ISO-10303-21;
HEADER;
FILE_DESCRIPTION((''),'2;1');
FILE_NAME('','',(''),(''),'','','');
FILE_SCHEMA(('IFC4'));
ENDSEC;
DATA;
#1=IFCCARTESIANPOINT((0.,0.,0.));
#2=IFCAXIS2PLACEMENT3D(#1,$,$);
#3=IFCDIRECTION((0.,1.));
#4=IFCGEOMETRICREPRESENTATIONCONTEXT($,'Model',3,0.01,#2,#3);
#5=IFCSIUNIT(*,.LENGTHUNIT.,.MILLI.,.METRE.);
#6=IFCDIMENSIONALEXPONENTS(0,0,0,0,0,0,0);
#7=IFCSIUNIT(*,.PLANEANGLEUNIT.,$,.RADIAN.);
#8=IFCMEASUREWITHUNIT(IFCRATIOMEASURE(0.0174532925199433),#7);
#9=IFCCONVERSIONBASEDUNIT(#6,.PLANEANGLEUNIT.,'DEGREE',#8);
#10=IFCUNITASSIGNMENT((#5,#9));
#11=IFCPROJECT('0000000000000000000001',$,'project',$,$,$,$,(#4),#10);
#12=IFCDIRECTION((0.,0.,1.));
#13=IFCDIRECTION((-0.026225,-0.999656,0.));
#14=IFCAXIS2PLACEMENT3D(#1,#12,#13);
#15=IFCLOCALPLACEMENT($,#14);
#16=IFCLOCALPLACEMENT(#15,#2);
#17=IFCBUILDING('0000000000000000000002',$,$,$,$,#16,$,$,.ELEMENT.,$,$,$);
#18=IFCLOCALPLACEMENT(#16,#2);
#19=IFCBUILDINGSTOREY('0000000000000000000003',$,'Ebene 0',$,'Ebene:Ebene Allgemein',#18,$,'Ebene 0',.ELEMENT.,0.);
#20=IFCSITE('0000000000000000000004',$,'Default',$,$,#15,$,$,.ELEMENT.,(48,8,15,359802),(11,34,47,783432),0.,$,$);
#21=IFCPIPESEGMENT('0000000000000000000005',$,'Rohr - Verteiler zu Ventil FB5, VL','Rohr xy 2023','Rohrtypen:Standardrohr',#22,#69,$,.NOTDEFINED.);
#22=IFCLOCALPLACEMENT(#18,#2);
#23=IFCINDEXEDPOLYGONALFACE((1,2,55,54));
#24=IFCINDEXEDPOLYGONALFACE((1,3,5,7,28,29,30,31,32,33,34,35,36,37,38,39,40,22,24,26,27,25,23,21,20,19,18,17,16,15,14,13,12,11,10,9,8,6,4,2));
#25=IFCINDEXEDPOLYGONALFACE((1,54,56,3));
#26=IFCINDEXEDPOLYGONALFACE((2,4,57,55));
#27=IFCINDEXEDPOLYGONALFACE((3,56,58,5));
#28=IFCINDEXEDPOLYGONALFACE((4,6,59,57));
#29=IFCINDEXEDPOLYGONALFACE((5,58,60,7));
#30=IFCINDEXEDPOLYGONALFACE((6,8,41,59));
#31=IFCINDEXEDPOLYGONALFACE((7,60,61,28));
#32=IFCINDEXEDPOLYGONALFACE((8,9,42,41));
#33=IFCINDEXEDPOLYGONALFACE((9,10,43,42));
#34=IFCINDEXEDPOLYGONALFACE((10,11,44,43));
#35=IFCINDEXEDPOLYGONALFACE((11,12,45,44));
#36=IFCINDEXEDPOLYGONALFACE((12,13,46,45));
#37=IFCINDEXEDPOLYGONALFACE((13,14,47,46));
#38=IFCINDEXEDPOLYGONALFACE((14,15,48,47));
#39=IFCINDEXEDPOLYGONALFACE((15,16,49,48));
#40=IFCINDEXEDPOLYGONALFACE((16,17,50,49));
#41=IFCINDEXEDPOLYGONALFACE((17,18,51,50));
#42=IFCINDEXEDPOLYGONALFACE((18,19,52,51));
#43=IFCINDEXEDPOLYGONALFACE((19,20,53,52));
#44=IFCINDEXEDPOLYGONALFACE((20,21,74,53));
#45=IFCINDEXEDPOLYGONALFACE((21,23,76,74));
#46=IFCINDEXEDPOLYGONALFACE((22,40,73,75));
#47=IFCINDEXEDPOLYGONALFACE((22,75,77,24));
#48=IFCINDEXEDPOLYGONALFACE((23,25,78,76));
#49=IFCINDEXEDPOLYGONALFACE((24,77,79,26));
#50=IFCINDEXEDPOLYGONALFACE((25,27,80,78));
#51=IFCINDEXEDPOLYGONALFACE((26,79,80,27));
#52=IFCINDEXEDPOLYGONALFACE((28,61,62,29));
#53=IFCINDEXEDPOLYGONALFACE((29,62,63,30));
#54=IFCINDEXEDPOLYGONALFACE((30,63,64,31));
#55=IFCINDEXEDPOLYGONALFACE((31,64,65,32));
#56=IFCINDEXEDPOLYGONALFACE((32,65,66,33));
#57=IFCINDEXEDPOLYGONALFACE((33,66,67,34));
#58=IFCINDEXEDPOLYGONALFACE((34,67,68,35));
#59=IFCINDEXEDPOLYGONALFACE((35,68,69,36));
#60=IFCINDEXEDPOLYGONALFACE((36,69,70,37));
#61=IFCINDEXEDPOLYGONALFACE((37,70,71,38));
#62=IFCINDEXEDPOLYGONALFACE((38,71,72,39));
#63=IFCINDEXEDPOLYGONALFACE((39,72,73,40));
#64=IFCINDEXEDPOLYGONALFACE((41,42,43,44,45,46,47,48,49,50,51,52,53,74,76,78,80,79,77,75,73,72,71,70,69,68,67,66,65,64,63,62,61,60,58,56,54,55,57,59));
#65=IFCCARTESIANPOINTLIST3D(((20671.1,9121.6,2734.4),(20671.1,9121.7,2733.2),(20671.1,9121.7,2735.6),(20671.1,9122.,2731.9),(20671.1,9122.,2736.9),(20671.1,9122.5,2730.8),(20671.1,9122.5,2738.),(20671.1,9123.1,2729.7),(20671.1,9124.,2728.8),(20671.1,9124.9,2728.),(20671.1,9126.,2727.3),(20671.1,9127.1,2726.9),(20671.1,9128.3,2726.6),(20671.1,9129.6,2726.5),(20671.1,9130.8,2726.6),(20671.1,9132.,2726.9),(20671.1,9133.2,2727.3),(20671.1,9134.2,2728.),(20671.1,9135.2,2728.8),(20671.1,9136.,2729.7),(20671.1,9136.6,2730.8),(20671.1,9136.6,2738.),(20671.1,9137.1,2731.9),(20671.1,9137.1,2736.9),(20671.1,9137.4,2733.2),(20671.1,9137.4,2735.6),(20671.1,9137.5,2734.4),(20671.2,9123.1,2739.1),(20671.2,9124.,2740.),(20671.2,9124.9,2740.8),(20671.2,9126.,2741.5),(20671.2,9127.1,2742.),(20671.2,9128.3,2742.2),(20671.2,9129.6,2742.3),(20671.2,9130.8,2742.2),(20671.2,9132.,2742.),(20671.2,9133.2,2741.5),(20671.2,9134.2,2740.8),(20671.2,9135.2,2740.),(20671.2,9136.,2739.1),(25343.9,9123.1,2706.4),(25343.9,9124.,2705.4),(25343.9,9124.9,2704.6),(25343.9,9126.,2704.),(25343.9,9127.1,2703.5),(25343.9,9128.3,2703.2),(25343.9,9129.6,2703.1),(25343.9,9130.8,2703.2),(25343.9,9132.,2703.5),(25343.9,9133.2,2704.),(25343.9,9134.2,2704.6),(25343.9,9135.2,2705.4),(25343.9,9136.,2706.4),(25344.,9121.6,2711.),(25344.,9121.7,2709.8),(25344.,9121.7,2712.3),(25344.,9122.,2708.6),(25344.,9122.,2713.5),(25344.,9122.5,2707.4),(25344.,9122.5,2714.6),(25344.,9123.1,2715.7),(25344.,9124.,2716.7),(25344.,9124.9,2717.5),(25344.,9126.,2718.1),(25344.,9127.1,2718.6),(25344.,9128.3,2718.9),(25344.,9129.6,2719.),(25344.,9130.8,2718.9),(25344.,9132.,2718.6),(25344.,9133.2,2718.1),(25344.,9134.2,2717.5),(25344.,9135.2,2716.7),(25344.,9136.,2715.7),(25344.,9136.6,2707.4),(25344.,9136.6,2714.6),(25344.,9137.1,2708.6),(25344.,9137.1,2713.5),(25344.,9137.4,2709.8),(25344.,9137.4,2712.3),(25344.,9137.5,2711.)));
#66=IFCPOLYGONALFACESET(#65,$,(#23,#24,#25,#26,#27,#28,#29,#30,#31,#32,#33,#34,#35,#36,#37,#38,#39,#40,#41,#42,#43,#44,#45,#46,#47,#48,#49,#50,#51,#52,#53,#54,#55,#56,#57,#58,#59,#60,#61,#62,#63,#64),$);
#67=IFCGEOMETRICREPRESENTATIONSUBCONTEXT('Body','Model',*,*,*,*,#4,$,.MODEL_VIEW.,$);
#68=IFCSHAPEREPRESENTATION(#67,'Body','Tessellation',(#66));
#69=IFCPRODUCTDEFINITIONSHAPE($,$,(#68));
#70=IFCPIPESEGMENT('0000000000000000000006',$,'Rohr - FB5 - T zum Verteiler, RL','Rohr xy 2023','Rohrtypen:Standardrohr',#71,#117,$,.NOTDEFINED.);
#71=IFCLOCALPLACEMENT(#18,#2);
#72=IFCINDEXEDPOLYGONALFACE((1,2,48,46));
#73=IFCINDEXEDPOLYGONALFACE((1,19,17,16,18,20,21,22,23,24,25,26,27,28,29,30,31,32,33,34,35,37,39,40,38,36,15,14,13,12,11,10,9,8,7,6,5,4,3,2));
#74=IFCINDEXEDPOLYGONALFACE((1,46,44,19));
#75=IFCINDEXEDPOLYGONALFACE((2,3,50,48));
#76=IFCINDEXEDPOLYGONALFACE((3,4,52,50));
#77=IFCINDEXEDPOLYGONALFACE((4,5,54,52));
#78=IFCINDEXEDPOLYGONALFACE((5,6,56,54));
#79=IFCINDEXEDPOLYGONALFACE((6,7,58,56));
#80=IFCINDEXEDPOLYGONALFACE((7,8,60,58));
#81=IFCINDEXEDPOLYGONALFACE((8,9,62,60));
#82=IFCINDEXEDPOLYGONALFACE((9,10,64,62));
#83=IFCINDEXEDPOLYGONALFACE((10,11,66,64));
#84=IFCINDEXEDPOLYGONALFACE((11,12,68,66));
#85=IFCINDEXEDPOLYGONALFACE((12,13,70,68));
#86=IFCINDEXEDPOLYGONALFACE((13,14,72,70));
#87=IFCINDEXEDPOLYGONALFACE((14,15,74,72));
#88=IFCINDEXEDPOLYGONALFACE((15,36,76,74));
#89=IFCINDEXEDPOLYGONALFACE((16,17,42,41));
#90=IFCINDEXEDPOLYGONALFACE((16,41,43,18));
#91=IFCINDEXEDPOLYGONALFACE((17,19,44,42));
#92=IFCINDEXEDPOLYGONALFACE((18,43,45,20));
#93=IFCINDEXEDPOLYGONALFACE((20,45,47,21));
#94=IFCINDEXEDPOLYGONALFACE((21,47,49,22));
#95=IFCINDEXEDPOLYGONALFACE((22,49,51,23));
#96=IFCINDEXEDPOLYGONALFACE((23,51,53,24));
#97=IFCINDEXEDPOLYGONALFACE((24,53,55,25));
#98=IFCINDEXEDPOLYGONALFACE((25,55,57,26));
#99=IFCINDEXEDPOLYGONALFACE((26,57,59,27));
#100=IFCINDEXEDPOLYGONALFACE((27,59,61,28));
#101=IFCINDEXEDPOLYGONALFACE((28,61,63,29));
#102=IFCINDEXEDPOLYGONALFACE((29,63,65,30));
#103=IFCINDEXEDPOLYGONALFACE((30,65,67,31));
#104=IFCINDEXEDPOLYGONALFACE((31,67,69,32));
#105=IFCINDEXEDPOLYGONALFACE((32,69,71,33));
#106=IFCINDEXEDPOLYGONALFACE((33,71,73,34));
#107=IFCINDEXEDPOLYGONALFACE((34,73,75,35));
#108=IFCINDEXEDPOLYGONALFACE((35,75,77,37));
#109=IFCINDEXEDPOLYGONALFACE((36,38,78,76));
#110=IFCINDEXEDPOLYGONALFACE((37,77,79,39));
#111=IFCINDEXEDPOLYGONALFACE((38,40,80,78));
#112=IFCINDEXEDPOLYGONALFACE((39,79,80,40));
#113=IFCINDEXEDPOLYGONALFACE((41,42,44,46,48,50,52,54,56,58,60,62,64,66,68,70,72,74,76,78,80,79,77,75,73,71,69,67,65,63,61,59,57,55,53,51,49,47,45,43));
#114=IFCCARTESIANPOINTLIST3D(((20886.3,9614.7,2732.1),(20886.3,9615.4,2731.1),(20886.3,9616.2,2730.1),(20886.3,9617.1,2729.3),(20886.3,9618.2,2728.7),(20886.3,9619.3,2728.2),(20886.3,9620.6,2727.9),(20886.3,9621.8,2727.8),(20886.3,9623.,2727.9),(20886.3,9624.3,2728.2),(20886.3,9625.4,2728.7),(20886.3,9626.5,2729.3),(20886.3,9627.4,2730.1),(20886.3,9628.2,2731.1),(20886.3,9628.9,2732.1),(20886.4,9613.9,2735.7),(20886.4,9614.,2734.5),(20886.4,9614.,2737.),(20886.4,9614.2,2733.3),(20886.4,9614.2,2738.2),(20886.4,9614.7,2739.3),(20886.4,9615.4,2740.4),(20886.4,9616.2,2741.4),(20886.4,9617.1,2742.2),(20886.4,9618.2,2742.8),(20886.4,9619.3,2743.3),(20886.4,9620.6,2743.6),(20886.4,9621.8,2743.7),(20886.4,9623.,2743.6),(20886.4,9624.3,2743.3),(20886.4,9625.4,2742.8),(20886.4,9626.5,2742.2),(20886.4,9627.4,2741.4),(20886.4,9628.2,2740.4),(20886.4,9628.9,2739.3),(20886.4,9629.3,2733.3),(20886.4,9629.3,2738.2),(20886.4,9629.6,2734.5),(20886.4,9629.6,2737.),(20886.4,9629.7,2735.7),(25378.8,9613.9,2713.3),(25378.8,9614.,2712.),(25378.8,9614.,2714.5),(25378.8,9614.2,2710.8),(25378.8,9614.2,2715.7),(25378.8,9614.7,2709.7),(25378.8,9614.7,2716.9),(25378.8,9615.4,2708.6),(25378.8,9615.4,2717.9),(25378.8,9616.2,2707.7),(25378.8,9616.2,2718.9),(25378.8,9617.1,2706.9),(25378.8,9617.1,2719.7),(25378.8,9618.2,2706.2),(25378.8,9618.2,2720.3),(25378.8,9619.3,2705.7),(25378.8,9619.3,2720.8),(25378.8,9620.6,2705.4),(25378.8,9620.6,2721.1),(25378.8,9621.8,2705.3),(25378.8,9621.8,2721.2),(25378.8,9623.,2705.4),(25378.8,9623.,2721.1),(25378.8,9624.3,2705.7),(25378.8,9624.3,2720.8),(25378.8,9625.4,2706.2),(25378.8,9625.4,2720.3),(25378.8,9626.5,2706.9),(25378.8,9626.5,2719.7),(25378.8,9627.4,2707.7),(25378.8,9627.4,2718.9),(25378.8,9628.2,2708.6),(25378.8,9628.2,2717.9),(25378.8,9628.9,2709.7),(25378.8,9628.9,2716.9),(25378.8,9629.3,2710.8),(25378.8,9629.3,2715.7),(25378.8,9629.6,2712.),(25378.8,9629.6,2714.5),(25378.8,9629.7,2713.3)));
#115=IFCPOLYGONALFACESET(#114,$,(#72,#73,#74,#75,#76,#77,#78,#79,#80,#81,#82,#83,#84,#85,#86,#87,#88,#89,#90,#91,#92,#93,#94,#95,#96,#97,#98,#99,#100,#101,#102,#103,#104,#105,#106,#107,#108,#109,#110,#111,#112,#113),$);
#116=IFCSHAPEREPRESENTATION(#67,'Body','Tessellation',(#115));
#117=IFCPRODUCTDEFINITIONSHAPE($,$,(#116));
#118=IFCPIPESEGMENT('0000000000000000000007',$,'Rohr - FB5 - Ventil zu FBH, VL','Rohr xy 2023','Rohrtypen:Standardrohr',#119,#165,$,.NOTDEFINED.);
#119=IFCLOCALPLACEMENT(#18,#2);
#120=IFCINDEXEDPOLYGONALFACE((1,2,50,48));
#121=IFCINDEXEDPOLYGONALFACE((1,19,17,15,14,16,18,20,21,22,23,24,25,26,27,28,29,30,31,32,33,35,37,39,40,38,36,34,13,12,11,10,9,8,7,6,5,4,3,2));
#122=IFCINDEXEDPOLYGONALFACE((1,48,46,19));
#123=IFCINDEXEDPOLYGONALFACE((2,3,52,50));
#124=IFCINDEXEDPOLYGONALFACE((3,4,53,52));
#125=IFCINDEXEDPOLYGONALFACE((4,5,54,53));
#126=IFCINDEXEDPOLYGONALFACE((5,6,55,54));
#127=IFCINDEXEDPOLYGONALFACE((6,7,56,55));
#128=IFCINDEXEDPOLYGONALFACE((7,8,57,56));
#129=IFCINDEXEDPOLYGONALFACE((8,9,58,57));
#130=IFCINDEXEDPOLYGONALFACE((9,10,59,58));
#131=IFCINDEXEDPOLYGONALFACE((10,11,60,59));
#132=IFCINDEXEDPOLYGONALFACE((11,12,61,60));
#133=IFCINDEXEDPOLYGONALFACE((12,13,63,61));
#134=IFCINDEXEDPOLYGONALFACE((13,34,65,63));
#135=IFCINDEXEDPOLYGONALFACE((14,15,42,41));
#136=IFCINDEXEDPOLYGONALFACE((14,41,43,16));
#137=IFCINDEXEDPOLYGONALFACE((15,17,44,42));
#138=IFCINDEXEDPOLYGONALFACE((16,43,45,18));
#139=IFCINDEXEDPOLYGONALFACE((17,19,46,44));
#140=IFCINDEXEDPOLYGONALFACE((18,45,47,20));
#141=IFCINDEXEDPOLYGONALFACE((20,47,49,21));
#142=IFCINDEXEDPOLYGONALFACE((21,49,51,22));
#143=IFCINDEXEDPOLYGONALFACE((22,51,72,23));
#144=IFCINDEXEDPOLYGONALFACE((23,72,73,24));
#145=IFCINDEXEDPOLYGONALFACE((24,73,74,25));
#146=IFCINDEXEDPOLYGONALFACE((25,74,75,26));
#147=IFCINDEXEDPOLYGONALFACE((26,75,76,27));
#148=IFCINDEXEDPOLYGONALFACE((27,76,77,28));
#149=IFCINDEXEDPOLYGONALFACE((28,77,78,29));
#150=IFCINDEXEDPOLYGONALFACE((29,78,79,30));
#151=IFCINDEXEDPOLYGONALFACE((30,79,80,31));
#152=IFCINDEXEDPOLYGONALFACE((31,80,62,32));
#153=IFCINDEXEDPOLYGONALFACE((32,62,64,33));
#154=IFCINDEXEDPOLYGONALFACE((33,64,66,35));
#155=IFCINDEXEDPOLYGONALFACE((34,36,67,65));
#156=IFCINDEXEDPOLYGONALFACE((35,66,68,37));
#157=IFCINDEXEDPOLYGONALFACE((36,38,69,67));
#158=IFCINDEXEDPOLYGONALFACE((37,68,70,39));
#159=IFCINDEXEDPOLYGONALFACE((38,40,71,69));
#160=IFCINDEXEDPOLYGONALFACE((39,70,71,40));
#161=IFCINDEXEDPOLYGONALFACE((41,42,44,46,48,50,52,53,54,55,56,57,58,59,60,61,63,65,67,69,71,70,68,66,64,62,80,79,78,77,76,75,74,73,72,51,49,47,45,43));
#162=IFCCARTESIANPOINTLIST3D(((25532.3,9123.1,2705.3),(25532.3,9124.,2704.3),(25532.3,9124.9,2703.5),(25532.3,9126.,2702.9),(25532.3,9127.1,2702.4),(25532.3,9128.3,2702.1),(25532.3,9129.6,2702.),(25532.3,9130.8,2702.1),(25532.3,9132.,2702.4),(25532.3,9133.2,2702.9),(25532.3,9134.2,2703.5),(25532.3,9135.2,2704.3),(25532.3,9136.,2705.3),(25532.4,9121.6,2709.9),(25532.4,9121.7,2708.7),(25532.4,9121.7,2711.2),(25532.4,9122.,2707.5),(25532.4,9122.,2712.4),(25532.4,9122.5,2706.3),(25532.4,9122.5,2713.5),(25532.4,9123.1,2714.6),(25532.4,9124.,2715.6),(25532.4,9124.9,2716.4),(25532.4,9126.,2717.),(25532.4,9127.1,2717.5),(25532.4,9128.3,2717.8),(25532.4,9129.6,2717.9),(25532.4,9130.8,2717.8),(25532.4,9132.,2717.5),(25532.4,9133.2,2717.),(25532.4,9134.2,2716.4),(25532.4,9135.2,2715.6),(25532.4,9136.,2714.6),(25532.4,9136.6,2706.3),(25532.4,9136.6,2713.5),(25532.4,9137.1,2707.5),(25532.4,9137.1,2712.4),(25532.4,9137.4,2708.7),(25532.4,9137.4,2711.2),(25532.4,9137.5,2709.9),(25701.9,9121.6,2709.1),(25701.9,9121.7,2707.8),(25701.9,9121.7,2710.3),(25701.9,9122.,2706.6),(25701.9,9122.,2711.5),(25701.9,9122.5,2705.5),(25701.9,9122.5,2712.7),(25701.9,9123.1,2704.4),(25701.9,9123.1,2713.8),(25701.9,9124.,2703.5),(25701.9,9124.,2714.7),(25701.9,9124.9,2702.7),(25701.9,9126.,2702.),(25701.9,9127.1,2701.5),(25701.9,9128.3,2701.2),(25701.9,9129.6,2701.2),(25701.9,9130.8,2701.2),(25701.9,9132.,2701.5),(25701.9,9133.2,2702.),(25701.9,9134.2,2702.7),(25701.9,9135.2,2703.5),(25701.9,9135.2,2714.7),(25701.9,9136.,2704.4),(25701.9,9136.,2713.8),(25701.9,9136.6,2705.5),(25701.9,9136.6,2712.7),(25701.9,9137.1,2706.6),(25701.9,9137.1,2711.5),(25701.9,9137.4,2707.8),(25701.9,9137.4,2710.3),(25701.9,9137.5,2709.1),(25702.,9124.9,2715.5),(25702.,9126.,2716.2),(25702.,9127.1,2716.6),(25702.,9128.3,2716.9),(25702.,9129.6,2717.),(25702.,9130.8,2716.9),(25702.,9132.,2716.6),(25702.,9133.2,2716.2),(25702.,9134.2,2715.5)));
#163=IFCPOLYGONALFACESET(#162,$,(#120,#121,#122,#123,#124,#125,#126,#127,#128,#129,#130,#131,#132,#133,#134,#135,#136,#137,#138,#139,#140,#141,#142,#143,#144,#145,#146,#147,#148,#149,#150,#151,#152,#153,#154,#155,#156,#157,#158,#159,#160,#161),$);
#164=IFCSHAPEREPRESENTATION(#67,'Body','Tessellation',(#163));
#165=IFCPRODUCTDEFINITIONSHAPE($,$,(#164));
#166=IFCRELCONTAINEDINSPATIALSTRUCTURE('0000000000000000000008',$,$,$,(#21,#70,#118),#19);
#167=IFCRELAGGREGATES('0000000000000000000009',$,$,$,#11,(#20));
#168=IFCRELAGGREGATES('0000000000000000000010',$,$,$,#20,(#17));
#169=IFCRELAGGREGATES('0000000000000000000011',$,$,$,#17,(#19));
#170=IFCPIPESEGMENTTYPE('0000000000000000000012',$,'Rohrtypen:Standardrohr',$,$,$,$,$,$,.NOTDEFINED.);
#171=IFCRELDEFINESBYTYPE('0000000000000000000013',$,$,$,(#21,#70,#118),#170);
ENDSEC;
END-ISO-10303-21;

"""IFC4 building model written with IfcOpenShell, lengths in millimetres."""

from ifc_helpers import new_model, entity, si_unit, converted_unit, direction, frame, origin, place, context, subcontext, project, spatial, indexed_curve, outline, extrude, type_object, element, save


model = new_model("IFC4")

# Units and contexts
model_context = context("Model", 3, precision=0.01, world=origin(), true_north=direction((0.0, 1.0)))
body_context = subcontext(model_context, "Body", "Model", "MODEL_VIEW")
ifc_project = project(units=[si_unit("LENGTHUNIT", "METRE", prefix="MILLI"), converted_unit("PLANEANGLEUNIT", "DEGREE", entity("IfcRatioMeasure", 0.0174532925199433), si_unit("PLANEANGLEUNIT", "RADIAN"), dimensions=[0, 0, 0, 0, 0, 0, 0])], contexts=[model_context])

# Site, building, storey
site_placement = place(None, frame((0.0, 0.0, 0.0), z_axis=(0.0, 0.0, 1.0), x_axis=(-0.026225, -0.999656, 0.0)))
site = spatial("IfcSite", under=ifc_project, at=site_placement, Name="Default", CompositionType="ELEMENT", RefLatitude=(48, 8, 15, 359802), RefLongitude=(11, 34, 47, 783432), RefElevation=0.0)
building_placement = place(site_placement, origin())
building = spatial("IfcBuilding", under=site, at=building_placement, CompositionType="ELEMENT")
storey_placement = place(building_placement, origin())
storey = spatial("IfcBuildingStorey", under=building, at=storey_placement, Name="Ebene 0", ObjectType="Ebene:Ebene Allgemein", LongName="Ebene 0", CompositionType="ELEMENT", Elevation=0.0)

# Pipe segments
pipe_segment_type = type_object("IfcPipeSegmentType", Name="Rohrtypen:Standardrohr", PredefinedType="NOTDEFINED")
pipe_segment_1_placement = place(storey_placement, origin())
element("IfcPipeSegment", 1, at=pipe_segment_1_placement, inside=storey, type_object=pipe_segment_type, Name="Rohr - Verteiler zu Ventil FB5, VL", Description="Rohr xy 2023", ObjectType="Rohrtypen:Standardrohr", PredefinedType="NOTDEFINED", context=body_context, shape_type="SweptSolid", body=[
    extrude(outline(indexed_curve([(7.9, 0.0), (7.8, 1.2), (7.6, 2.5), (7.1, 3.6), (6.4, 4.7), (5.6, 5.6), (4.7, 6.4), (3.6, 7.1), (2.5, 7.6), (1.2, 7.8), (0.0, 7.9), (-1.2, 7.8), (-2.5, 7.6), (-3.6, 7.1), (-4.7, 6.4), (-5.6, 5.6), (-6.4, 4.7), (-7.1, 3.6), (-7.6, 2.5), (-7.8, 1.2), (-7.9, 0.0), (-7.8, -1.2), (-7.6, -2.5), (-7.1, -3.6), (-6.4, -4.7), (-5.6, -5.6), (-4.7, -6.4), (-3.6, -7.1), (-2.5, -7.6), (-1.2, -7.8), (0.0, -7.9), (1.2, -7.8), (2.5, -7.6), (3.6, -7.1), (4.7, -6.4), (5.6, -5.6), (6.4, -4.7), (7.1, -3.6), (7.6, -2.5), (7.8, -1.2), (7.9, 0.0)], self_intersect=False)), frame((25344.0, 9129.6, 2711.0), z_axis=(-0.999988, 0.0, 0.005), x_axis=(0.0, 1.0, 0.0)), (0.0, 0.0, 1.0), 4672.9),
])
pipe_segment_2_placement = place(storey_placement, origin())
element("IfcPipeSegment", 2, at=pipe_segment_2_placement, inside=storey, type_object=pipe_segment_type, Name="Rohr - FB5 - T zum Verteiler, RL", Description="Rohr xy 2023", ObjectType="Rohrtypen:Standardrohr", PredefinedType="NOTDEFINED", context=body_context, shape_type="SweptSolid", body=[
    extrude(outline(indexed_curve([(7.9, 0.0), (7.8, 1.2), (7.6, 2.5), (7.1, 3.6), (6.4, 4.7), (5.6, 5.6), (4.7, 6.4), (3.6, 7.1), (2.5, 7.6), (1.2, 7.8), (0.0, 7.9), (-1.2, 7.8), (-2.5, 7.6), (-3.6, 7.1), (-4.7, 6.4), (-5.6, 5.6), (-6.4, 4.7), (-7.1, 3.6), (-7.6, 2.5), (-7.8, 1.2), (-7.9, 0.0), (-7.8, -1.2), (-7.6, -2.5), (-7.1, -3.6), (-6.4, -4.7), (-5.6, -5.6), (-4.7, -6.4), (-3.6, -7.1), (-2.5, -7.6), (-1.2, -7.8), (0.0, -7.9), (1.2, -7.8), (2.5, -7.6), (3.6, -7.1), (4.7, -6.4), (5.6, -5.6), (6.4, -4.7), (7.1, -3.6), (7.6, -2.5), (7.8, -1.2), (7.9, 0.0)], self_intersect=False)), frame((25378.8, 9621.8, 2713.3), z_axis=(-0.999988, 0.0, 0.005), x_axis=(0.0, 1.0, 0.0)), (0.0, 0.0, 1.0), 4492.5),
])
pipe_segment_3_placement = place(storey_placement, origin())
element("IfcPipeSegment", 3, at=pipe_segment_3_placement, inside=storey, type_object=pipe_segment_type, Name="Rohr - FB5 - Ventil zu FBH, VL", Description="Rohr xy 2023", ObjectType="Rohrtypen:Standardrohr", PredefinedType="NOTDEFINED", context=body_context, shape_type="SweptSolid", body=[
    extrude(outline(indexed_curve([(7.9, 0.0), (7.8, 1.2), (7.6, 2.5), (7.1, 3.6), (6.4, 4.7), (5.6, 5.6), (4.7, 6.4), (3.6, 7.1), (2.5, 7.6), (1.2, 7.8), (0.0, 7.9), (-1.2, 7.8), (-2.5, 7.6), (-3.6, 7.1), (-4.7, 6.4), (-5.6, 5.6), (-6.4, 4.7), (-7.1, 3.6), (-7.6, 2.5), (-7.8, 1.2), (-7.9, 0.0), (-7.8, -1.2), (-7.6, -2.5), (-7.1, -3.6), (-6.4, -4.7), (-5.6, -5.6), (-4.7, -6.4), (-3.6, -7.1), (-2.5, -7.6), (-1.2, -7.8), (0.0, -7.9), (1.2, -7.8), (2.5, -7.6), (3.6, -7.1), (4.7, -6.4), (5.6, -5.6), (6.4, -4.7), (7.1, -3.6), (7.6, -2.5), (7.8, -1.2), (7.9, 0.0)], self_intersect=False)), frame((25532.4, 9129.6, 2709.9), z_axis=(0.999988, 0.0, -0.005), x_axis=(0.0, 1.0, 0.0)), (0.0, 0.0, 1.0), 169.5),
])

save(model, "model.ifc")
